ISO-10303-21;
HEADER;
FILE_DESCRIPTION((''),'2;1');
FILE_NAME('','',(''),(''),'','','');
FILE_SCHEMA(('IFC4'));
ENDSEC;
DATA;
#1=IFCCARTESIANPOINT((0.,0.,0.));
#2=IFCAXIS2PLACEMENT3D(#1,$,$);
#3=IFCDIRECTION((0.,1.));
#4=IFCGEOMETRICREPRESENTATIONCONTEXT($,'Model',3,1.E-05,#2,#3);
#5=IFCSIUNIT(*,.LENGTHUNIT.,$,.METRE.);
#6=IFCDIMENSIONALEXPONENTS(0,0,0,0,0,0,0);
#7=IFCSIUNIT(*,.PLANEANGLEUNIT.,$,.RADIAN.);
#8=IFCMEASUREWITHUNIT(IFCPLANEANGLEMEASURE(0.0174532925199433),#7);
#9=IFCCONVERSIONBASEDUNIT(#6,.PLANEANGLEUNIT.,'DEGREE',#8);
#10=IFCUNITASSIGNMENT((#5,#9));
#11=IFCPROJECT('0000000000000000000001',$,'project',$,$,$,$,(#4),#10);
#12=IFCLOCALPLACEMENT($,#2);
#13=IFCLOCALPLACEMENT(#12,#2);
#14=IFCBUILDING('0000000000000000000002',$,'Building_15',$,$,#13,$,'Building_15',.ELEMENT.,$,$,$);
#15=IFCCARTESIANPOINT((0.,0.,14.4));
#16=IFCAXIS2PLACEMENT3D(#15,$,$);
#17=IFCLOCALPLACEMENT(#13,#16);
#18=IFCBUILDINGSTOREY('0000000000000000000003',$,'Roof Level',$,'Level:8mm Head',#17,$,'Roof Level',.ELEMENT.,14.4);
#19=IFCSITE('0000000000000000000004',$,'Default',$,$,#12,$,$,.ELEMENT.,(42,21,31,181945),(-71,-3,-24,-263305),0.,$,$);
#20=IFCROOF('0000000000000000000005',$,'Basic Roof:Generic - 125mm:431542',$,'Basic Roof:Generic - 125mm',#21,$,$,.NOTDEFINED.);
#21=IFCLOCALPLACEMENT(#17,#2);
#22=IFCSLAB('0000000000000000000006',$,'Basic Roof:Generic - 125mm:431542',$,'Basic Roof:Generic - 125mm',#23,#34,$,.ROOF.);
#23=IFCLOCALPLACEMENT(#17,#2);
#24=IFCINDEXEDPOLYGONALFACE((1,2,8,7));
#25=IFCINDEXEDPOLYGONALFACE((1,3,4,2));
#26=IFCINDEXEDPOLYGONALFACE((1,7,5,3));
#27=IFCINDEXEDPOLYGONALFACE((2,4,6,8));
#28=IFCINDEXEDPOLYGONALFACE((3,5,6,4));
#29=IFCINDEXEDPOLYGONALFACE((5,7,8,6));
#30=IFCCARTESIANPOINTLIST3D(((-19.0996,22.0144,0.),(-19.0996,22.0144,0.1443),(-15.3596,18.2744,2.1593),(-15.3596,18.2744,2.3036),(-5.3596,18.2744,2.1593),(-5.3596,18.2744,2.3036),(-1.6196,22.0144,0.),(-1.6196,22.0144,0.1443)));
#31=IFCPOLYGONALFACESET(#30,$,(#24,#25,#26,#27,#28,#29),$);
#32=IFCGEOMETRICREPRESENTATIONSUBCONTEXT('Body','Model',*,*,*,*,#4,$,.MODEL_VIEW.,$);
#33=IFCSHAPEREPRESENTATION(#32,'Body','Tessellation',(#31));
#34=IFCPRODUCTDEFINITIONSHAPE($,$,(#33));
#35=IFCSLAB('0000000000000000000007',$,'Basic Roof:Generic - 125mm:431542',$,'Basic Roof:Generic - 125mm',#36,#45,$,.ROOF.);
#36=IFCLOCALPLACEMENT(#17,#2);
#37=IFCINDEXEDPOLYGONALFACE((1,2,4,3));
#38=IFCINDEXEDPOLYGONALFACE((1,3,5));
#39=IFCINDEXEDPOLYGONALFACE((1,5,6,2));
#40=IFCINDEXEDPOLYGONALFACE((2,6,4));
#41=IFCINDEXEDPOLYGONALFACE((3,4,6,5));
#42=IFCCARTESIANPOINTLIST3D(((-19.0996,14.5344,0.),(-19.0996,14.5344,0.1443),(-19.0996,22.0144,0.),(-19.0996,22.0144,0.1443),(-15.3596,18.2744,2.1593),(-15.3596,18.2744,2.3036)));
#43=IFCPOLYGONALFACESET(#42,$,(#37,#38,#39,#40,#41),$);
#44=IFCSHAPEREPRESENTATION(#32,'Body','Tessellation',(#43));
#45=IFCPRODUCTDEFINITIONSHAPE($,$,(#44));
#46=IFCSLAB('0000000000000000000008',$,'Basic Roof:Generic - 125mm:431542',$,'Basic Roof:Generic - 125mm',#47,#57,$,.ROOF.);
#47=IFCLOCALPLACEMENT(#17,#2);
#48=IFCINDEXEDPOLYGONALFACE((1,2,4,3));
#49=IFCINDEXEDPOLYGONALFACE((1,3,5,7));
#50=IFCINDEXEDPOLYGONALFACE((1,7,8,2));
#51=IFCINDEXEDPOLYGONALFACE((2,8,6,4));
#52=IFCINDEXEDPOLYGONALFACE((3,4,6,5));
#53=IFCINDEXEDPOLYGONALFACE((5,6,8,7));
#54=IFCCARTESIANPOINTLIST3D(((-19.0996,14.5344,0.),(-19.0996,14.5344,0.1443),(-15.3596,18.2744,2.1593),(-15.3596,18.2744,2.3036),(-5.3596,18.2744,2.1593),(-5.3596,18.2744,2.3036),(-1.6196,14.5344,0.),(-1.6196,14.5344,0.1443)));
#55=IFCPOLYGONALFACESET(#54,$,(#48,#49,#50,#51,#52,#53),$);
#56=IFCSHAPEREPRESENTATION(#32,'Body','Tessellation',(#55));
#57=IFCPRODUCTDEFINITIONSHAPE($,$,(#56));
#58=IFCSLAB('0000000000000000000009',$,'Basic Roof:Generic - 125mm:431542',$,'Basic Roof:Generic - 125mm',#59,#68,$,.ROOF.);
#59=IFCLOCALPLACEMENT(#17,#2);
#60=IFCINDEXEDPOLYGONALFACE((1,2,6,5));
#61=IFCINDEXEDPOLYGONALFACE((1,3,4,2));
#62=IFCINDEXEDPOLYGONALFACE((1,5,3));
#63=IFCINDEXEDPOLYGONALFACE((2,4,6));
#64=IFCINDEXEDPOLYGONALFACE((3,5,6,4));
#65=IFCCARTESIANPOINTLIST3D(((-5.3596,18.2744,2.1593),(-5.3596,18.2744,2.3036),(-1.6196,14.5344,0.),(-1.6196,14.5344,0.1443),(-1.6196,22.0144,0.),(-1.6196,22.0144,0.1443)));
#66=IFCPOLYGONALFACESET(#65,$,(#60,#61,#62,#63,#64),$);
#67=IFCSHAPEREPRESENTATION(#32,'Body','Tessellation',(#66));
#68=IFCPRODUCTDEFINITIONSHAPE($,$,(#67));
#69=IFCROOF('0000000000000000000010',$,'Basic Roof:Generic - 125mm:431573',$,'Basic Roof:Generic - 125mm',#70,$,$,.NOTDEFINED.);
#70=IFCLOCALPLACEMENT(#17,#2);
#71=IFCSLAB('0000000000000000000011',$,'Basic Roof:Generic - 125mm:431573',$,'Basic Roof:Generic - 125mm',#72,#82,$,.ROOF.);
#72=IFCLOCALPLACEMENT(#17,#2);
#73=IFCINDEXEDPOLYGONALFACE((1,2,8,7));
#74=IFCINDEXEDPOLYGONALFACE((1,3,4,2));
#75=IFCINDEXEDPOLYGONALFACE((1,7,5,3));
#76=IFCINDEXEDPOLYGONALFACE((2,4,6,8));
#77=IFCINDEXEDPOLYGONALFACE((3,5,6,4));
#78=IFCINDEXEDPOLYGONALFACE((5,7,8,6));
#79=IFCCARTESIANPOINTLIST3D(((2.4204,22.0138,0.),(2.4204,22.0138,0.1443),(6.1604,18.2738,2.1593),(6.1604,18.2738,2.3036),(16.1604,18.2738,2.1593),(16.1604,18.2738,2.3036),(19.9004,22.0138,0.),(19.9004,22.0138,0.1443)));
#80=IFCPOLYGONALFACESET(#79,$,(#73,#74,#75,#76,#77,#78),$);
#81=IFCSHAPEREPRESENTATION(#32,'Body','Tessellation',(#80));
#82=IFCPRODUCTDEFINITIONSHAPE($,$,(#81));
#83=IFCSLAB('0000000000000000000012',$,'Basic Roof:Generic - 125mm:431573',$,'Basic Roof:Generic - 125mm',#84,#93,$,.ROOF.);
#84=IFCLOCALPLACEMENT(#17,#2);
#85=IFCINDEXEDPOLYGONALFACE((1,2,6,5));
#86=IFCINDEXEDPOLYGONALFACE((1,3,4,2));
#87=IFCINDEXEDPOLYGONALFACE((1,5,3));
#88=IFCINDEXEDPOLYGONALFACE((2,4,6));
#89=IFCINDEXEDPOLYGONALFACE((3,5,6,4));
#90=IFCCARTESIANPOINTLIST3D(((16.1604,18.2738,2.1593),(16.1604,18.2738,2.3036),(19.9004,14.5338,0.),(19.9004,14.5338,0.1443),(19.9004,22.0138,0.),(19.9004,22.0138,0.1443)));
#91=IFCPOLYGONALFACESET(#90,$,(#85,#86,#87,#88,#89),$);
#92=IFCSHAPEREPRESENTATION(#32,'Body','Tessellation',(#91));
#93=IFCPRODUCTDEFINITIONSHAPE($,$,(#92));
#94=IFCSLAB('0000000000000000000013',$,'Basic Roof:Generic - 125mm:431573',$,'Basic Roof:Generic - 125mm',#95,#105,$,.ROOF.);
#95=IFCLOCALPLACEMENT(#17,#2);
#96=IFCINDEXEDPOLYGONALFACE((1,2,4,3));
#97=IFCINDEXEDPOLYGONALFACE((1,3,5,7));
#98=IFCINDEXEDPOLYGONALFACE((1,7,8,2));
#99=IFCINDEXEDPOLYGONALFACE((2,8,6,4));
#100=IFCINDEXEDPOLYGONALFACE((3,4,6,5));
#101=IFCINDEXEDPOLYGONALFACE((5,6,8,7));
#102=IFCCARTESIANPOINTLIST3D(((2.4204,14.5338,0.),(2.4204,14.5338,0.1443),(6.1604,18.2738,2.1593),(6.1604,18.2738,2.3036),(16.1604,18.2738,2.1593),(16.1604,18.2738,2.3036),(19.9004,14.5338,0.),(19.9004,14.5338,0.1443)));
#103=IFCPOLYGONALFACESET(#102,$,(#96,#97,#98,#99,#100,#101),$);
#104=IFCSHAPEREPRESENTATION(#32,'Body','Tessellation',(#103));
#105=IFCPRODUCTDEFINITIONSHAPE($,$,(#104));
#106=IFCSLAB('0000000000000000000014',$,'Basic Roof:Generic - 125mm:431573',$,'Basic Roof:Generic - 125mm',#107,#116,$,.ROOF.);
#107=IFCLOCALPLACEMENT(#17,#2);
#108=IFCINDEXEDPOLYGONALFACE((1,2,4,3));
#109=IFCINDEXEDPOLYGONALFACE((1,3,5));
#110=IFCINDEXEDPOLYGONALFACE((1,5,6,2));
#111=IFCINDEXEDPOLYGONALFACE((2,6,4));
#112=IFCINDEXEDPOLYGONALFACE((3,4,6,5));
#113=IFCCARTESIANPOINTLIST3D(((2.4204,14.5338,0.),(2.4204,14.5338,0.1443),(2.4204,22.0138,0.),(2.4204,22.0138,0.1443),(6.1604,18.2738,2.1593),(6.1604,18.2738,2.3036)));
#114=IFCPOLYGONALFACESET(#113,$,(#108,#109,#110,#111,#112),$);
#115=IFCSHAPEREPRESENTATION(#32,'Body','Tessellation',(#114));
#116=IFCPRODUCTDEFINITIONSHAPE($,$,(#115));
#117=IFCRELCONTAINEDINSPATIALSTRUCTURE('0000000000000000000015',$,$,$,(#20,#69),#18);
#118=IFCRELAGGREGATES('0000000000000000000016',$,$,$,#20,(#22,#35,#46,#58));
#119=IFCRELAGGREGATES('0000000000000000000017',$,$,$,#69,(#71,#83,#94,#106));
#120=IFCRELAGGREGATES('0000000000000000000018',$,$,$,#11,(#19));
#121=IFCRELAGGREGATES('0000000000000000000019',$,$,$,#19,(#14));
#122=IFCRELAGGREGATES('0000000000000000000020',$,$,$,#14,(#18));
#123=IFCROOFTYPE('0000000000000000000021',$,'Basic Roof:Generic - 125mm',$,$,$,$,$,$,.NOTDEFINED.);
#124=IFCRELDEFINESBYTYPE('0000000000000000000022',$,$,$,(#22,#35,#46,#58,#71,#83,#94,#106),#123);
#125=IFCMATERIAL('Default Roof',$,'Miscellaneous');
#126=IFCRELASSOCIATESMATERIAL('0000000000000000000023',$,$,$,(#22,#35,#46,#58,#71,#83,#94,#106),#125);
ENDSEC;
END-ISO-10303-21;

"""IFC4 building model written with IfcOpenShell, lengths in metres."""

from ifc_helpers import new_model, entity, si_unit, converted_unit, direction, frame, origin, place, context, subcontext, project, spatial, indexed_curve, outline, extrude, material, type_object, element, aggregate, save


model = new_model("IFC4")

# Units and contexts
model_context = context("Model", 3, precision=1e-05, world=origin(), true_north=direction((0.0, 1.0)))
body_context = subcontext(model_context, "Body", "Model", "MODEL_VIEW")
ifc_project = project(units=[si_unit("LENGTHUNIT", "METRE"), converted_unit("PLANEANGLEUNIT", "DEGREE", entity("IfcPlaneAngleMeasure", 0.0174532925199433), si_unit("PLANEANGLEUNIT", "RADIAN"), dimensions=[0, 0, 0, 0, 0, 0, 0])], contexts=[model_context])

# Site, building, storey
site_placement = place(None, origin())
site = spatial("IfcSite", under=ifc_project, at=site_placement, Name="Default", CompositionType="ELEMENT", RefLatitude=(42, 21, 31, 181945), RefLongitude=(-71, -3, -24, -263305), RefElevation=0.0)
building_placement = place(site_placement, origin())
building = spatial("IfcBuilding", under=site, at=building_placement, Name="Building_15", LongName="Building_15", CompositionType="ELEMENT")
storey_placement = place(building_placement, frame((0.0, 0.0, 14.4)))
storey = spatial("IfcBuildingStorey", under=building, at=storey_placement, Name="Roof Level", ObjectType="Level:8mm Head", LongName="Roof Level", CompositionType="ELEMENT", Elevation=14.4)

# Roofs, slabs
roof_1_placement = place(storey_placement, frame((-19.0996, 14.5344, 0.0)))
roof_1 = element("IfcRoof", 1, at=roof_1_placement, inside=storey, Name="Basic Roof:Generic - 125mm:431542", ObjectType="Basic Roof:Generic - 125mm", PredefinedType="NOTDEFINED")
ifc_material = material(Name="Default Roof", Category="Miscellaneous")
roof_type = type_object("IfcRoofType", Name="Basic Roof:Generic - 125mm", PredefinedType="NOTDEFINED")
slab_1_placement = place(roof_1_placement, origin())
slab_1 = element("IfcSlab", 2, at=slab_1_placement, type_object=roof_type, material=ifc_material, Name="Basic Roof:Generic - 125mm:431542", ObjectType="Basic Roof:Generic - 125mm", PredefinedType="ROOF", context=body_context, shape_type="SweptSolid", body=[
    extrude(outline(indexed_curve([(8.74, 2.1593), (-8.74, 2.1593), (-5.0, -2.1593), (5.0, -2.1593), (8.74, 2.1593)], self_intersect=False)), frame((8.74, 5.61, 1.0796), z_axis=(0.0, 0.5, 0.866025), x_axis=(1.0, 0.0, 0.0)), (0.0, -0.5, 0.866025), 0.1443),
])
slab_2_placement = place(roof_1_placement, origin())
slab_2 = element("IfcSlab", 3, at=slab_2_placement, type_object=roof_type, material=ifc_material, Name="Basic Roof:Generic - 125mm:431542", ObjectType="Basic Roof:Generic - 125mm", PredefinedType="ROOF", context=body_context, shape_type="SweptSolid", body=[
    extrude(outline(indexed_curve([(-2.1593, 3.74), (-2.1593, -3.74), (2.1593, 0.0), (-2.1593, 3.74)], self_intersect=False)), frame((1.87, 3.74, 1.0796), z_axis=(-0.5, 0.0, 0.866025), x_axis=(0.866025, 0.0, 0.5)), (0.5, 0.0, 0.866025), 0.1443),
])
slab_3_placement = place(roof_1_placement, origin())
slab_3 = element("IfcSlab", 4, at=slab_3_placement, type_object=roof_type, material=ifc_material, Name="Basic Roof:Generic - 125mm:431542", ObjectType="Basic Roof:Generic - 125mm", PredefinedType="ROOF", context=body_context, shape_type="SweptSolid", body=[
    extrude(outline(indexed_curve([(-8.74, -2.1593), (8.74, -2.1593), (5.0, 2.1593), (-5.0, 2.1593), (-8.74, -2.1593)], self_intersect=False)), frame((8.74, 1.87, 1.0796), z_axis=(0.0, -0.5, 0.866025), x_axis=(1.0, 0.0, 0.0)), (0.0, 0.5, 0.866025), 0.1443),
])
slab_4_placement = place(roof_1_placement, origin())
slab_4 = element("IfcSlab", 5, at=slab_4_placement, type_object=roof_type, material=ifc_material, Name="Basic Roof:Generic - 125mm:431542", ObjectType="Basic Roof:Generic - 125mm", PredefinedType="ROOF", context=body_context, shape_type="SweptSolid", body=[
    extrude(outline(indexed_curve([(-2.1593, 0.0), (2.1593, -3.74), (2.1593, 3.74), (-2.1593, 0.0)], self_intersect=False)), frame((15.61, 3.74, 1.0796), z_axis=(0.5, 0.0, 0.866025), x_axis=(0.866025, 0.0, -0.5)), (-0.5, 0.0, 0.866025), 0.1443),
])
aggregate(roof_1, [slab_1, slab_2, slab_3, slab_4])
roof_2_placement = place(storey_placement, frame((2.4204, 14.5338, 0.0)))
roof_2 = element("IfcRoof", 6, at=roof_2_placement, inside=storey, Name="Basic Roof:Generic - 125mm:431573", ObjectType="Basic Roof:Generic - 125mm", PredefinedType="NOTDEFINED")
slab_5_placement = place(roof_2_placement, origin())
slab_5 = element("IfcSlab", 7, at=slab_5_placement, type_object=roof_type, material=ifc_material, Name="Basic Roof:Generic - 125mm:431573", ObjectType="Basic Roof:Generic - 125mm", PredefinedType="ROOF", context=body_context, shape_type="SweptSolid", body=[
    extrude(outline(indexed_curve([(-5.0, -2.1593), (5.0, -2.1593), (8.74, 2.1593), (-8.74, 2.1593), (-5.0, -2.1593)], self_intersect=False)), frame((8.74, 5.61, 1.0796), z_axis=(0.0, 0.5, 0.866025), x_axis=(1.0, 0.0, 0.0)), (0.0, -0.5, 0.866025), 0.1443),
])
slab_6_placement = place(roof_2_placement, origin())
slab_6 = element("IfcSlab", 8, at=slab_6_placement, type_object=roof_type, material=ifc_material, Name="Basic Roof:Generic - 125mm:431573", ObjectType="Basic Roof:Generic - 125mm", PredefinedType="ROOF", context=body_context, shape_type="SweptSolid", body=[
    extrude(outline(indexed_curve([(2.1593, -3.74), (2.1593, 3.74), (-2.1593, 0.0), (2.1593, -3.74)], self_intersect=False)), frame((15.61, 3.74, 1.0796), z_axis=(0.5, 0.0, 0.866025), x_axis=(0.866025, 0.0, -0.5)), (-0.5, 0.0, 0.866025), 0.1443),
])
slab_7_placement = place(roof_2_placement, origin())
slab_7 = element("IfcSlab", 9, at=slab_7_placement, type_object=roof_type, material=ifc_material, Name="Basic Roof:Generic - 125mm:431573", ObjectType="Basic Roof:Generic - 125mm", PredefinedType="ROOF", context=body_context, shape_type="SweptSolid", body=[
    extrude(outline(indexed_curve([(-8.74, -2.1593), (8.74, -2.1593), (5.0, 2.1593), (-5.0, 2.1593), (-8.74, -2.1593)], self_intersect=False)), frame((8.74, 1.87, 1.0796), z_axis=(0.0, -0.5, 0.866025), x_axis=(1.0, 0.0, 0.0)), (0.0, 0.5, 0.866025), 0.1443),
])
slab_8_placement = place(roof_2_placement, origin())
slab_8 = element("IfcSlab", 10, at=slab_8_placement, type_object=roof_type, material=ifc_material, Name="Basic Roof:Generic - 125mm:431573", ObjectType="Basic Roof:Generic - 125mm", PredefinedType="ROOF", context=body_context, shape_type="SweptSolid", body=[
    extrude(outline(indexed_curve([(-2.1593, 3.74), (-2.1593, -3.74), (2.1593, 0.0), (-2.1593, 3.74)], self_intersect=False)), frame((1.87, 3.74, 1.0796), z_axis=(-0.5, 0.0, 0.866025), x_axis=(0.866025, 0.0, 0.5)), (0.5, 0.0, 0.866025), 0.1443),
])
aggregate(roof_2, [slab_5, slab_6, slab_7, slab_8])

save(model, "model.ifc")
